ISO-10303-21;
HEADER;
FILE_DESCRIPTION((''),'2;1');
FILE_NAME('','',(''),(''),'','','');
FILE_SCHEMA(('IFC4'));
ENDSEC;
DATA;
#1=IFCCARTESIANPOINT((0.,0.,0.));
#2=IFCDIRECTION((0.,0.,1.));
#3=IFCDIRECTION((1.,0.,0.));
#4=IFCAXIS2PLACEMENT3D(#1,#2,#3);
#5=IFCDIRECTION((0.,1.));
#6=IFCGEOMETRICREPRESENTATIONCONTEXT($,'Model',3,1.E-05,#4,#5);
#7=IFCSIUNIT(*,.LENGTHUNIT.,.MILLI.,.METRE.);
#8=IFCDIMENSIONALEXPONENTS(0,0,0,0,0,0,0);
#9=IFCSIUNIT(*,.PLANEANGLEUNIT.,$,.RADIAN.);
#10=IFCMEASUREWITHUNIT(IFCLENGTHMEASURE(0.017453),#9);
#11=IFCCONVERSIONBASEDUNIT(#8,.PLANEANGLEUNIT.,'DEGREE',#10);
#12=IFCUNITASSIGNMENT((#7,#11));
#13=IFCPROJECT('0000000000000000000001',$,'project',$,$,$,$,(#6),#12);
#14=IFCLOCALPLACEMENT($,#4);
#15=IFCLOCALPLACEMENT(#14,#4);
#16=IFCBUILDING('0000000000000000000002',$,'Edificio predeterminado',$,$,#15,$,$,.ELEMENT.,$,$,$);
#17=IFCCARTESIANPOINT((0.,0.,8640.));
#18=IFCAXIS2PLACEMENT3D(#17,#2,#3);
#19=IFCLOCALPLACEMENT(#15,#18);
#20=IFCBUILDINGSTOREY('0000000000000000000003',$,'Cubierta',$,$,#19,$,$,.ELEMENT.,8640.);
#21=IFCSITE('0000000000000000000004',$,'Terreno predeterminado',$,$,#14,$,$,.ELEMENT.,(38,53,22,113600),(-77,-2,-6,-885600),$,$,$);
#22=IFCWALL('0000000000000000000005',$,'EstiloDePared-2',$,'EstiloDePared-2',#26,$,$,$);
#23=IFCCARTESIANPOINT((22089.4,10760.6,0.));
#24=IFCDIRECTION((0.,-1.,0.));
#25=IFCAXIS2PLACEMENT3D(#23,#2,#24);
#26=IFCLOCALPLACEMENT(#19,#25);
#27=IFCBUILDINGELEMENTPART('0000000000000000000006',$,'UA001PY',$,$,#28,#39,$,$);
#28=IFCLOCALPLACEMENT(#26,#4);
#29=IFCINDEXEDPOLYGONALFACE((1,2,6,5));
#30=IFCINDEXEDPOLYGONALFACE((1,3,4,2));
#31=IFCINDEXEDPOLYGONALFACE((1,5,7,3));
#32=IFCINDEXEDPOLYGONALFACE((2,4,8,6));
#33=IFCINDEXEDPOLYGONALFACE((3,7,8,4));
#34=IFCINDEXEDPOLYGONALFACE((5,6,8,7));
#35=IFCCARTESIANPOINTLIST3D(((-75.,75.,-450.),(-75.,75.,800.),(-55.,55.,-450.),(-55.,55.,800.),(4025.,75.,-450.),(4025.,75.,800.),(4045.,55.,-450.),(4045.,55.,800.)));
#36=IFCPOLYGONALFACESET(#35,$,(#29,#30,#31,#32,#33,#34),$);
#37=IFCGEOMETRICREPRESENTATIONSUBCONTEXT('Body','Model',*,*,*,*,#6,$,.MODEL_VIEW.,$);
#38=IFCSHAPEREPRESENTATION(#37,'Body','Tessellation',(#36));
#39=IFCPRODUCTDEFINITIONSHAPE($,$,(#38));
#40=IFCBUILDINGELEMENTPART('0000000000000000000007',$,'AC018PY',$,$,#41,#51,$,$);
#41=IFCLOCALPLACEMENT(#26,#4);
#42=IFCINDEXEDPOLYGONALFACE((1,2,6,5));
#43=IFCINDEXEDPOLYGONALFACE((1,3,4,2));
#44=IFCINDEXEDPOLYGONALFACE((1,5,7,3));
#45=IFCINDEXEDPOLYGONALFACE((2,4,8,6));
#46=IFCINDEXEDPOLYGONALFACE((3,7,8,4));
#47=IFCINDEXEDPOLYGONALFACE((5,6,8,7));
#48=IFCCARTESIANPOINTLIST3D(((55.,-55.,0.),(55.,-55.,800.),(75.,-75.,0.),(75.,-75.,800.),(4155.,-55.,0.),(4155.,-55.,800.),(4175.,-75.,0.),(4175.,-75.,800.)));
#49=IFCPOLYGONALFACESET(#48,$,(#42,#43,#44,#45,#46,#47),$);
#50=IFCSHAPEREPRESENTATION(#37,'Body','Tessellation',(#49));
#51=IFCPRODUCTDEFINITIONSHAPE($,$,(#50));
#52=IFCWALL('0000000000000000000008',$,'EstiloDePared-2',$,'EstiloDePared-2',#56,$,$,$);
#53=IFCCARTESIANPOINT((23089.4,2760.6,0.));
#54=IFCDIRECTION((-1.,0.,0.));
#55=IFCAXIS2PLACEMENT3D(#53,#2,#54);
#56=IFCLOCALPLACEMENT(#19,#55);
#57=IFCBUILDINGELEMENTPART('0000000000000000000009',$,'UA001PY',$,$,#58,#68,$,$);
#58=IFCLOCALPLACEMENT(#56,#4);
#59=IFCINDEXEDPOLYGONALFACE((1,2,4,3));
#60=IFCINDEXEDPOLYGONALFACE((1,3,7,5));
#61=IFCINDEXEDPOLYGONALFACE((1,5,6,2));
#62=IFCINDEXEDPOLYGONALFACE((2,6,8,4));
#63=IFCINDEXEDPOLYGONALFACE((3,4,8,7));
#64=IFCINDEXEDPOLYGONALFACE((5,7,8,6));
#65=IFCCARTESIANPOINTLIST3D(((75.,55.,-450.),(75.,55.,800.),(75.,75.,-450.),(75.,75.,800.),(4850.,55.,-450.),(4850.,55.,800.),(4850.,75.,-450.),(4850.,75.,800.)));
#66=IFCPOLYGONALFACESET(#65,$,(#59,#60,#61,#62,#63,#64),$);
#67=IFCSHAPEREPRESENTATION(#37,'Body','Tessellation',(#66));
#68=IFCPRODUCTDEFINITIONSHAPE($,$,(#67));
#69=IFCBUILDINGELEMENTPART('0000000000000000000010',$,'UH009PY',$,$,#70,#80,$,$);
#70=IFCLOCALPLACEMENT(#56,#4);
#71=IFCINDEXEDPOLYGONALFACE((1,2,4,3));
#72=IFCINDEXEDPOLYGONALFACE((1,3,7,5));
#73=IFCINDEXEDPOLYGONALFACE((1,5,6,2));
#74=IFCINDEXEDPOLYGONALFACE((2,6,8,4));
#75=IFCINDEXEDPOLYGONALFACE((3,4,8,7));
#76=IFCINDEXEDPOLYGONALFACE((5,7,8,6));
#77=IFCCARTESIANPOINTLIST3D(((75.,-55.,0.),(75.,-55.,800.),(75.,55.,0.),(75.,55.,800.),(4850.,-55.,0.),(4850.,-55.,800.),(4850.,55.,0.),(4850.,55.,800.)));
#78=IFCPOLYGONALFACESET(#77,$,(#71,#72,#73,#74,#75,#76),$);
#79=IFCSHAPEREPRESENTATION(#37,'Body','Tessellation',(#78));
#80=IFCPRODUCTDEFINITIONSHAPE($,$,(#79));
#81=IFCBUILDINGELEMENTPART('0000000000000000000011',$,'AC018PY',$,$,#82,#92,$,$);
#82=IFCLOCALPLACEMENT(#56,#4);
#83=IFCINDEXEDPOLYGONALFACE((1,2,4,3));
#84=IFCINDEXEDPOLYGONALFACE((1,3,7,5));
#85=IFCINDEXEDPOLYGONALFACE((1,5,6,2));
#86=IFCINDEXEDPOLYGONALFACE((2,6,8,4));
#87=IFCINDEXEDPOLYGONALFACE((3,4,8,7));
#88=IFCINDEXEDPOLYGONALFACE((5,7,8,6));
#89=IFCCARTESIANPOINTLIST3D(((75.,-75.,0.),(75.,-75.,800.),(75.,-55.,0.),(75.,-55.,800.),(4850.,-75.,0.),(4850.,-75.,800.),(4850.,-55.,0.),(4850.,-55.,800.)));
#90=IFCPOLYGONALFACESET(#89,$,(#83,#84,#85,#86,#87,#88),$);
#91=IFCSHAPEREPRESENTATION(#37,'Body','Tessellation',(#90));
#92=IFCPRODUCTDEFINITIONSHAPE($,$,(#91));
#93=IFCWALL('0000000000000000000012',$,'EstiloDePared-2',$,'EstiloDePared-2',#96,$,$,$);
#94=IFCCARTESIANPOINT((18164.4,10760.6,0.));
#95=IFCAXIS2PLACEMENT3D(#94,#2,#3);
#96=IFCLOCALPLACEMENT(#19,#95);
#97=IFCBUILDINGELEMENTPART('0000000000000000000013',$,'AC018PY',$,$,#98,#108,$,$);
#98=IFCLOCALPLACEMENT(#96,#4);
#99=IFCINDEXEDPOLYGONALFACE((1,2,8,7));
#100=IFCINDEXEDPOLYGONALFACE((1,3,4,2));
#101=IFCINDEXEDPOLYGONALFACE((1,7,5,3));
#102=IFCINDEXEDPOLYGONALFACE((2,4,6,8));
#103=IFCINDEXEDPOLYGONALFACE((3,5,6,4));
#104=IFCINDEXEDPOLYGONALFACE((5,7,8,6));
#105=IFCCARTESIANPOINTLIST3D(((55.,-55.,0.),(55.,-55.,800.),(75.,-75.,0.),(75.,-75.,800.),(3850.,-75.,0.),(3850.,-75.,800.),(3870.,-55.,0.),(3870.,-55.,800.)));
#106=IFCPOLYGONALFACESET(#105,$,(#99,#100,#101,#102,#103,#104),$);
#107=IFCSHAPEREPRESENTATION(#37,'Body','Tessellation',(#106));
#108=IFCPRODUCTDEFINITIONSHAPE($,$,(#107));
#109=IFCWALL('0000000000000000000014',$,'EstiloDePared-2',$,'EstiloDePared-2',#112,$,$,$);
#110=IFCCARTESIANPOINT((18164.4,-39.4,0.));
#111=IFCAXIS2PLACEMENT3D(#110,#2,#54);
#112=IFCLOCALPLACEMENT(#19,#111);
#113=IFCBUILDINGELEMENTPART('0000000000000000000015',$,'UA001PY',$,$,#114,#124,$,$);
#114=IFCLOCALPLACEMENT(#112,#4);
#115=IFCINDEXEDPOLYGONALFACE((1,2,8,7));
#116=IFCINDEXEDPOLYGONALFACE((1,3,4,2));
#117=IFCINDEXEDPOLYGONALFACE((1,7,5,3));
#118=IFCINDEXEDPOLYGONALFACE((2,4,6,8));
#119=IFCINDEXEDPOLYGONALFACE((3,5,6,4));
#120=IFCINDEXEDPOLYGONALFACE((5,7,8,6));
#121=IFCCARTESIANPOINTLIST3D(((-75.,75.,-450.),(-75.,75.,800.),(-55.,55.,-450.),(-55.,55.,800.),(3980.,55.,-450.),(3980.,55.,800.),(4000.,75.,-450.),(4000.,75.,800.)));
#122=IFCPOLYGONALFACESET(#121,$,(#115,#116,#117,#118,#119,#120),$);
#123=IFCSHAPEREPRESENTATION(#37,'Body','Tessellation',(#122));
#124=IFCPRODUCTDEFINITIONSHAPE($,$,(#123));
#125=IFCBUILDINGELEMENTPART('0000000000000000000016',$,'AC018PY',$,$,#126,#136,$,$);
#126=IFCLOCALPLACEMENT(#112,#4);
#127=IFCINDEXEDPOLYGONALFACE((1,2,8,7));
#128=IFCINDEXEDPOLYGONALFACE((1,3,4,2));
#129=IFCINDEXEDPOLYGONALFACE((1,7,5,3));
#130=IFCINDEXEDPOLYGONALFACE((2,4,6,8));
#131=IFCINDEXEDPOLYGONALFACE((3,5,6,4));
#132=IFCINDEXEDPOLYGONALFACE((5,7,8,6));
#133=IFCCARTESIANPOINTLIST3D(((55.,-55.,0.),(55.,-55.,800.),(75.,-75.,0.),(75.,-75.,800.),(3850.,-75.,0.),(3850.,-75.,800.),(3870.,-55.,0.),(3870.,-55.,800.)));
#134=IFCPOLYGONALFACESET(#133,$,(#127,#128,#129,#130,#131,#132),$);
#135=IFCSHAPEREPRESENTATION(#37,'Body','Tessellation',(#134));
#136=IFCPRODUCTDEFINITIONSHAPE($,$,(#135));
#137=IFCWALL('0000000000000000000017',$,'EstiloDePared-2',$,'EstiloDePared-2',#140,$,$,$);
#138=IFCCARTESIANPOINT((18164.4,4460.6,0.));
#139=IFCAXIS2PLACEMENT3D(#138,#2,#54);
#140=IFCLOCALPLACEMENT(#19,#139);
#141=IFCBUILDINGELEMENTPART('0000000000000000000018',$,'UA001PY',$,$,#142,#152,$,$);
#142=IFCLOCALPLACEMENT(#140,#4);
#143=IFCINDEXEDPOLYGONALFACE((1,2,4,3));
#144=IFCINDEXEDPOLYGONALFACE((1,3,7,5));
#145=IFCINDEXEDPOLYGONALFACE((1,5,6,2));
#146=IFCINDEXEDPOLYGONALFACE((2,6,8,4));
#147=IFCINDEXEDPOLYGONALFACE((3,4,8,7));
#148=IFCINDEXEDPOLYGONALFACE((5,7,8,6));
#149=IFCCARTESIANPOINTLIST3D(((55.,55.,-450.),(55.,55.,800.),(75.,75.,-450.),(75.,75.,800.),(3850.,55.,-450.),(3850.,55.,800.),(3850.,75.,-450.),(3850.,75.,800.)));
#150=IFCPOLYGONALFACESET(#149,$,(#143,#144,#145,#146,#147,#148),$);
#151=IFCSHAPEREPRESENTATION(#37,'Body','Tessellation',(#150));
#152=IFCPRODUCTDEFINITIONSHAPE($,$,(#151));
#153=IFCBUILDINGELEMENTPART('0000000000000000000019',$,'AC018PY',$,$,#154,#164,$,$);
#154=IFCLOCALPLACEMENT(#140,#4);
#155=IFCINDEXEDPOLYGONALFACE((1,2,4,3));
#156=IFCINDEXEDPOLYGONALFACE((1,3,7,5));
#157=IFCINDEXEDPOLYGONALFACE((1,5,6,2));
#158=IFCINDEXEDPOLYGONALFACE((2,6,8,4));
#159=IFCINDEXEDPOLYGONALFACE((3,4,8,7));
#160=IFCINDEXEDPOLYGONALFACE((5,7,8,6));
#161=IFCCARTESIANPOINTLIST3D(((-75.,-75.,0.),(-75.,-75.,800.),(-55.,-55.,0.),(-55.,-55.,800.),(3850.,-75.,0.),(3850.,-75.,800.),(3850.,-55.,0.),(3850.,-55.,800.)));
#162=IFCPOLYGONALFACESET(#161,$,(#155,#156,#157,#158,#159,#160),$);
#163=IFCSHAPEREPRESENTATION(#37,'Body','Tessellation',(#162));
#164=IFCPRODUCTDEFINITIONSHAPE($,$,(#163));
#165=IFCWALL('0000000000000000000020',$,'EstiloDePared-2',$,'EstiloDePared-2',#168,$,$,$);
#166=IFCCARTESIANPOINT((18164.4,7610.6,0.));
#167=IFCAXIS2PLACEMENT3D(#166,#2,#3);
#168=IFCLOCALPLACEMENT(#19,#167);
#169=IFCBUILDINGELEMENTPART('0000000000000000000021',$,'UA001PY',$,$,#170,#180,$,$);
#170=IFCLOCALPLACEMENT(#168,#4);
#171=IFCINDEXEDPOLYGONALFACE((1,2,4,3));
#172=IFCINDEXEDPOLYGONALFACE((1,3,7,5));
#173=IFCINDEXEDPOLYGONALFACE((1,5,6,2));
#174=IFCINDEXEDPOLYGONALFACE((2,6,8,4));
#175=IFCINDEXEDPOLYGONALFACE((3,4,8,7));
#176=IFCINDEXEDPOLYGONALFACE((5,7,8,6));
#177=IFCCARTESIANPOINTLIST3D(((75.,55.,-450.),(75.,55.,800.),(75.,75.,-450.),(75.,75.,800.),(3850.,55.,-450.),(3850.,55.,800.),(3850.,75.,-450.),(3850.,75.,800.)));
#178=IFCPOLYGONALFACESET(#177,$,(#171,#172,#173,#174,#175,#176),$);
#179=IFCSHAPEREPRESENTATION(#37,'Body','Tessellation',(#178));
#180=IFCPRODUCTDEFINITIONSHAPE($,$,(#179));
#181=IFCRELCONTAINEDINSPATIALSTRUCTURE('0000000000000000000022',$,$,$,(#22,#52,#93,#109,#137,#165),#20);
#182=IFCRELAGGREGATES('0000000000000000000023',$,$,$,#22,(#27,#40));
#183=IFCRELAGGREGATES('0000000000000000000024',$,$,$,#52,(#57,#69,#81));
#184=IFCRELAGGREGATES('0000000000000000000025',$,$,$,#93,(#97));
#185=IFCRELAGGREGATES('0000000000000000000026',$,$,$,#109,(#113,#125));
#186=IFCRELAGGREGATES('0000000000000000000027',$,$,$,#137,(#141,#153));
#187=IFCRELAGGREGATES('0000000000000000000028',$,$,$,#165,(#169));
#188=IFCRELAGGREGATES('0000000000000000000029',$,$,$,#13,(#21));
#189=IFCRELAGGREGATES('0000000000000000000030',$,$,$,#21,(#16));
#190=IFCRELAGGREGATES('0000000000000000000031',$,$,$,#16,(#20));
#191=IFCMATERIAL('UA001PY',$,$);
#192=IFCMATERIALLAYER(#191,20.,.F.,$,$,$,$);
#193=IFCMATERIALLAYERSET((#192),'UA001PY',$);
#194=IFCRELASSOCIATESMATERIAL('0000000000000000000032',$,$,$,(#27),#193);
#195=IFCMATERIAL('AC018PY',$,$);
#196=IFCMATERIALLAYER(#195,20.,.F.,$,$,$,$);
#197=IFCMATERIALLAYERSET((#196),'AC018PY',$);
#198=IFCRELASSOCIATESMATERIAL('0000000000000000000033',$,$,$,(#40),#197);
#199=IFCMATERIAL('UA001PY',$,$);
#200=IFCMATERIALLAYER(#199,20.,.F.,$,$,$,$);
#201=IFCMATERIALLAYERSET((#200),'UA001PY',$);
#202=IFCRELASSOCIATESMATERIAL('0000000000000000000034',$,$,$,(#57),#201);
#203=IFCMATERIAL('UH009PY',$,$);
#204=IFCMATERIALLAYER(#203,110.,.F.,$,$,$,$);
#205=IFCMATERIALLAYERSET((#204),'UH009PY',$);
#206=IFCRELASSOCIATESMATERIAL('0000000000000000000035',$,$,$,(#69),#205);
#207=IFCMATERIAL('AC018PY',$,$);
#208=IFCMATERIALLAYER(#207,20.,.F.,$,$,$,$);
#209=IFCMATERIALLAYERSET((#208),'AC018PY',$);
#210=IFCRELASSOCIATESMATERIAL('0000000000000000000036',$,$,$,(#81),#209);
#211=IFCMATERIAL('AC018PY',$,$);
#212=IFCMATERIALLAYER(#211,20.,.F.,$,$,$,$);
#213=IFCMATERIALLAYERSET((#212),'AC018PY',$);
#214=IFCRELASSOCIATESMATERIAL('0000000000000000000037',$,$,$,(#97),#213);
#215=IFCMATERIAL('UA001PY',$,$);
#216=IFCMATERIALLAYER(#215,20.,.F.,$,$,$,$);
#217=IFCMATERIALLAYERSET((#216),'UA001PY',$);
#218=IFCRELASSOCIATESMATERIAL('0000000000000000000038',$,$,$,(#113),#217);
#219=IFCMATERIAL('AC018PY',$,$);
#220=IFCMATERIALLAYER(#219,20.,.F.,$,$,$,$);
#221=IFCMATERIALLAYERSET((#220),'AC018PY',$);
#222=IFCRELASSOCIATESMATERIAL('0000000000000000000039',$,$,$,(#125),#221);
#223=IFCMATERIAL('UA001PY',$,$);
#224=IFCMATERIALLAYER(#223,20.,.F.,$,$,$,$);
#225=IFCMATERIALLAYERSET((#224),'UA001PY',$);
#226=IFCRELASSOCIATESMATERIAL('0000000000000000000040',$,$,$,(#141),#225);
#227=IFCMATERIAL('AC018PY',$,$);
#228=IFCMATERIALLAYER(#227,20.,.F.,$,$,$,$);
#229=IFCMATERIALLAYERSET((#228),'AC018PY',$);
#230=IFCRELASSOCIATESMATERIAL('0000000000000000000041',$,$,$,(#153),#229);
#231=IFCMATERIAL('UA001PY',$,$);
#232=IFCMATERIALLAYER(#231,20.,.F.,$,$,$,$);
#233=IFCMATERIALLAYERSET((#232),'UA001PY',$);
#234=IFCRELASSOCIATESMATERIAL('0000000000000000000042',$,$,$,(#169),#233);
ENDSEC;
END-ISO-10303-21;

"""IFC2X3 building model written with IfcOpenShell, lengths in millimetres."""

from ifc_helpers import new_model, entity, si_unit, converted_unit, direction, frame, origin_with_axes, place, context, subcontext, project, spatial, polyline, outline, extrude, material, layer, layer_set, layer_usage, element, aggregate, save


model = new_model("IFC2X3")

# Units and contexts
model_context = context("Model", 3, precision=1e-05, world=origin_with_axes(), true_north=direction((0.0, 1.0)))
body_context = subcontext(model_context, "Body", "Model", "MODEL_VIEW")
ifc_project = project(units=[si_unit("LENGTHUNIT", "METRE", prefix="MILLI"), converted_unit("PLANEANGLEUNIT", "DEGREE", entity("IfcLengthMeasure", 0.017453), si_unit("PLANEANGLEUNIT", "RADIAN"), dimensions=[0, 0, 0, 0, 0, 0, 0])], contexts=[model_context])

# Site, building, storey
site_placement = place(None, origin_with_axes())
site = spatial("IfcSite", under=ifc_project, at=site_placement, Name="Terreno predeterminado", CompositionType="ELEMENT", RefLatitude=(38, 53, 22, 113600), RefLongitude=(-77, -2, -6, -885600))
building_placement = place(site_placement, origin_with_axes())
building = spatial("IfcBuilding", under=site, at=building_placement, Name="Edificio predeterminado", CompositionType="ELEMENT")
storey_placement = place(building_placement, frame((0.0, 0.0, 8640.0), z_axis=(0.0, 0.0, 1.0), x_axis=(1.0, 0.0, 0.0)))
storey = spatial("IfcBuildingStorey", under=building, at=storey_placement, Name="Cubierta", CompositionType="ELEMENT", Elevation=8640.0)

# Walls, building element parts
wall_1_placement = place(storey_placement, frame((22089.4, 10760.6, 0.0), z_axis=(0.0, 0.0, 1.0), x_axis=(0.0, -1.0, 0.0)))
wall_1 = element("IfcWall", 1, at=wall_1_placement, inside=storey, Name="EstiloDePared-2", ObjectType="EstiloDePared-2")
ifc_material_1 = material(Name="UA001PY")
ifc_layer_1 = layer(ifc_material_1, 20.0, ventilated=False)
ifc_layer_set_1 = layer_set([ifc_layer_1], Name="UA001PY")
ifc_layer_usage_1 = layer_usage(ifc_layer_set_1, "AXIS2", "NEGATIVE", -75.0)
building_element_part_1_placement = place(wall_1_placement, origin_with_axes())
building_element_part_1 = element("IfcBuildingElementPart", 2, at=building_element_part_1_placement, material=ifc_layer_usage_1, Name="UA001PY", context=body_context, shape_type="SweptSolid", body=[
    extrude(outline(polyline([(4025.0, 75.0), (4045.0, 55.0), (-55.0, 55.0), (-75.0, 75.0), (4025.0, 75.0)])), frame((0.0, 0.0, -450.0), z_axis=(0.0, 0.0, 1.0), x_axis=(1.0, 0.0, 0.0)), (0.0, 0.0, 1.0), 1250.0),
])
ifc_material_2 = material(Name="AC018PY")
ifc_layer_2 = layer(ifc_material_2, 20.0, ventilated=False)
ifc_layer_set_2 = layer_set([ifc_layer_2], Name="AC018PY")
ifc_layer_usage_2 = layer_usage(ifc_layer_set_2, "AXIS2", "NEGATIVE", 55.0)
building_element_part_2_placement = place(wall_1_placement, origin_with_axes())
building_element_part_2 = element("IfcBuildingElementPart", 3, at=building_element_part_2_placement, material=ifc_layer_usage_2, Name="AC018PY", context=body_context, shape_type="SweptSolid", body=[
    extrude(outline(polyline([(4155.0, -55.0), (4175.0, -75.0), (75.0, -75.0), (55.0, -55.0), (4155.0, -55.0)])), origin_with_axes(), (0.0, 0.0, 1.0), 800.0),
])
aggregate(wall_1, [building_element_part_1, building_element_part_2])
wall_2_placement = place(storey_placement, frame((23089.4, 2760.6, 0.0), z_axis=(0.0, 0.0, 1.0), x_axis=(-1.0, 0.0, 0.0)))
wall_2 = element("IfcWall", 4, at=wall_2_placement, inside=storey, Name="EstiloDePared-2", ObjectType="EstiloDePared-2")
ifc_material_3 = material(Name="UA001PY")
ifc_layer_3 = layer(ifc_material_3, 20.0, ventilated=False)
ifc_layer_set_3 = layer_set([ifc_layer_3], Name="UA001PY")
ifc_layer_usage_3 = layer_usage(ifc_layer_set_3, "AXIS2", "NEGATIVE", -75.0)
building_element_part_3_placement = place(wall_2_placement, origin_with_axes())
building_element_part_3 = element("IfcBuildingElementPart", 5, at=building_element_part_3_placement, material=ifc_layer_usage_3, Name="UA001PY", context=body_context, shape_type="SweptSolid", body=[
    extrude(outline(polyline([(4850.0, 75.0), (4850.0, 55.0), (75.0, 55.0), (75.0, 75.0), (4850.0, 75.0)])), frame((0.0, 0.0, -450.0), z_axis=(0.0, 0.0, 1.0), x_axis=(1.0, 0.0, 0.0)), (0.0, 0.0, 1.0), 1250.0),
])
ifc_material_4 = material(Name="UH009PY")
ifc_layer_4 = layer(ifc_material_4, 110.0, ventilated=False)
ifc_layer_set_4 = layer_set([ifc_layer_4], Name="UH009PY")
ifc_layer_usage_4 = layer_usage(ifc_layer_set_4, "AXIS2", "NEGATIVE", -55.0)
building_element_part_4_placement = place(wall_2_placement, origin_with_axes())
building_element_part_4 = element("IfcBuildingElementPart", 6, at=building_element_part_4_placement, material=ifc_layer_usage_4, Name="UH009PY", context=body_context, shape_type="SweptSolid", body=[
    extrude(outline(polyline([(4850.0, 55.0), (4850.0, -55.0), (75.0, -55.0), (75.0, 55.0), (4850.0, 55.0)])), origin_with_axes(), (0.0, 0.0, 1.0), 800.0),
])
ifc_material_5 = material(Name="AC018PY")
ifc_layer_5 = layer(ifc_material_5, 20.0, ventilated=False)
ifc_layer_set_5 = layer_set([ifc_layer_5], Name="AC018PY")
ifc_layer_usage_5 = layer_usage(ifc_layer_set_5, "AXIS2", "NEGATIVE", 55.0)
building_element_part_5_placement = place(wall_2_placement, origin_with_axes())
building_element_part_5 = element("IfcBuildingElementPart", 7, at=building_element_part_5_placement, material=ifc_layer_usage_5, Name="AC018PY", context=body_context, shape_type="SweptSolid", body=[
    extrude(outline(polyline([(4850.0, -55.0), (4850.0, -75.0), (75.0, -75.0), (75.0, -55.0), (4850.0, -55.0)])), origin_with_axes(), (0.0, 0.0, 1.0), 800.0),
])
aggregate(wall_2, [building_element_part_3, building_element_part_4, building_element_part_5])

# Wall, building element part
wall_3_placement = place(storey_placement, frame((18164.4, 10760.6, 0.0), z_axis=(0.0, 0.0, 1.0), x_axis=(1.0, 0.0, 0.0)))
wall_3 = element("IfcWall", 8, at=wall_3_placement, inside=storey, Name="EstiloDePared-2", ObjectType="EstiloDePared-2")
ifc_material_6 = material(Name="AC018PY")
ifc_layer_6 = layer(ifc_material_6, 20.0, ventilated=False)
ifc_layer_set_6 = layer_set([ifc_layer_6], Name="AC018PY")
ifc_layer_usage_6 = layer_usage(ifc_layer_set_6, "AXIS2", "NEGATIVE", 55.0)
building_element_part_6_placement = place(wall_3_placement, origin_with_axes())
building_element_part_6 = element("IfcBuildingElementPart", 9, at=building_element_part_6_placement, material=ifc_layer_usage_6, Name="AC018PY", context=body_context, shape_type="SweptSolid", body=[
    extrude(outline(polyline([(3870.0, -55.0), (3850.0, -75.0), (75.0, -75.0), (55.0, -55.0), (3870.0, -55.0)])), origin_with_axes(), (0.0, 0.0, 1.0), 800.0),
])
aggregate(wall_3, [building_element_part_6])

# Walls, building element parts
wall_4_placement = place(storey_placement, frame((18164.4, -39.4, 0.0), z_axis=(0.0, 0.0, 1.0), x_axis=(-1.0, 0.0, 0.0)))
wall_4 = element("IfcWall", 10, at=wall_4_placement, inside=storey, Name="EstiloDePared-2", ObjectType="EstiloDePared-2")
ifc_material_7 = material(Name="UA001PY")
ifc_layer_7 = layer(ifc_material_7, 20.0, ventilated=False)
ifc_layer_set_7 = layer_set([ifc_layer_7], Name="UA001PY")
ifc_layer_usage_7 = layer_usage(ifc_layer_set_7, "AXIS2", "NEGATIVE", -75.0)
building_element_part_7_placement = place(wall_4_placement, origin_with_axes())
building_element_part_7 = element("IfcBuildingElementPart", 11, at=building_element_part_7_placement, material=ifc_layer_usage_7, Name="UA001PY", context=body_context, shape_type="SweptSolid", body=[
    extrude(outline(polyline([(4000.0, 75.0), (3980.0, 55.0), (-55.0, 55.0), (-75.0, 75.0), (4000.0, 75.0)])), frame((0.0, 0.0, -450.0), z_axis=(0.0, 0.0, 1.0), x_axis=(1.0, 0.0, 0.0)), (0.0, 0.0, 1.0), 1250.0),
])
ifc_material_8 = material(Name="AC018PY")
ifc_layer_8 = layer(ifc_material_8, 20.0, ventilated=False)
ifc_layer_set_8 = layer_set([ifc_layer_8], Name="AC018PY")
ifc_layer_usage_8 = layer_usage(ifc_layer_set_8, "AXIS2", "NEGATIVE", 55.0)
building_element_part_8_placement = place(wall_4_placement, origin_with_axes())
building_element_part_8 = element("IfcBuildingElementPart", 12, at=building_element_part_8_placement, material=ifc_layer_usage_8, Name="AC018PY", context=body_context, shape_type="SweptSolid", body=[
    extrude(outline(polyline([(3870.0, -55.0), (3850.0, -75.0), (75.0, -75.0), (55.0, -55.0), (3870.0, -55.0)])), origin_with_axes(), (0.0, 0.0, 1.0), 800.0),
])
aggregate(wall_4, [building_element_part_7, building_element_part_8])
wall_5_placement = place(storey_placement, frame((18164.4, 4460.6, 0.0), z_axis=(0.0, 0.0, 1.0), x_axis=(-1.0, 0.0, 0.0)))
wall_5 = element("IfcWall", 13, at=wall_5_placement, inside=storey, Name="EstiloDePared-2", ObjectType="EstiloDePared-2")
ifc_material_9 = material(Name="UA001PY")
ifc_layer_9 = layer(ifc_material_9, 20.0, ventilated=False)
ifc_layer_set_9 = layer_set([ifc_layer_9], Name="UA001PY")
ifc_layer_usage_9 = layer_usage(ifc_layer_set_9, "AXIS2", "NEGATIVE", -75.0)
building_element_part_9_placement = place(wall_5_placement, origin_with_axes())
building_element_part_9 = element("IfcBuildingElementPart", 14, at=building_element_part_9_placement, material=ifc_layer_usage_9, Name="UA001PY", context=body_context, shape_type="SweptSolid", body=[
    extrude(outline(polyline([(3850.0, 75.0), (3850.0, 55.0), (55.0, 55.0), (75.0, 75.0), (3850.0, 75.0)])), frame((0.0, 0.0, -450.0), z_axis=(0.0, 0.0, 1.0), x_axis=(1.0, 0.0, 0.0)), (0.0, 0.0, 1.0), 1250.0),
])
ifc_material_10 = material(Name="AC018PY")
ifc_layer_10 = layer(ifc_material_10, 20.0, ventilated=False)
ifc_layer_set_10 = layer_set([ifc_layer_10], Name="AC018PY")
ifc_layer_usage_10 = layer_usage(ifc_layer_set_10, "AXIS2", "NEGATIVE", 55.0)
building_element_part_10_placement = place(wall_5_placement, origin_with_axes())
building_element_part_10 = element("IfcBuildingElementPart", 15, at=building_element_part_10_placement, material=ifc_layer_usage_10, Name="AC018PY", context=body_context, shape_type="SweptSolid", body=[
    extrude(outline(polyline([(3850.0, -55.0), (3850.0, -75.0), (-75.0, -75.0), (-55.0, -55.0), (3850.0, -55.0)])), origin_with_axes(), (0.0, 0.0, 1.0), 800.0),
])
aggregate(wall_5, [building_element_part_9, building_element_part_10])
wall_6_placement = place(storey_placement, frame((18164.4, 7610.6, 0.0), z_axis=(0.0, 0.0, 1.0), x_axis=(1.0, 0.0, 0.0)))
wall_6 = element("IfcWall", 16, at=wall_6_placement, inside=storey, Name="EstiloDePared-2", ObjectType="EstiloDePared-2")
ifc_material_11 = material(Name="UA001PY")
ifc_layer_11 = layer(ifc_material_11, 20.0, ventilated=False)
ifc_layer_set_11 = layer_set([ifc_layer_11], Name="UA001PY")
ifc_layer_usage_11 = layer_usage(ifc_layer_set_11, "AXIS2", "NEGATIVE", -75.0)
building_element_part_11_placement = place(wall_6_placement, origin_with_axes())
building_element_part_11 = element("IfcBuildingElementPart", 17, at=building_element_part_11_placement, material=ifc_layer_usage_11, Name="UA001PY", context=body_context, shape_type="SweptSolid", body=[
    extrude(outline(polyline([(3850.0, 75.0), (3850.0, 55.0), (75.0, 55.0), (75.0, 75.0), (3850.0, 75.0)])), frame((0.0, 0.0, -450.0), z_axis=(0.0, 0.0, 1.0), x_axis=(1.0, 0.0, 0.0)), (0.0, 0.0, 1.0), 1250.0),
])
aggregate(wall_6, [building_element_part_11])

save(model, "model.ifc")
